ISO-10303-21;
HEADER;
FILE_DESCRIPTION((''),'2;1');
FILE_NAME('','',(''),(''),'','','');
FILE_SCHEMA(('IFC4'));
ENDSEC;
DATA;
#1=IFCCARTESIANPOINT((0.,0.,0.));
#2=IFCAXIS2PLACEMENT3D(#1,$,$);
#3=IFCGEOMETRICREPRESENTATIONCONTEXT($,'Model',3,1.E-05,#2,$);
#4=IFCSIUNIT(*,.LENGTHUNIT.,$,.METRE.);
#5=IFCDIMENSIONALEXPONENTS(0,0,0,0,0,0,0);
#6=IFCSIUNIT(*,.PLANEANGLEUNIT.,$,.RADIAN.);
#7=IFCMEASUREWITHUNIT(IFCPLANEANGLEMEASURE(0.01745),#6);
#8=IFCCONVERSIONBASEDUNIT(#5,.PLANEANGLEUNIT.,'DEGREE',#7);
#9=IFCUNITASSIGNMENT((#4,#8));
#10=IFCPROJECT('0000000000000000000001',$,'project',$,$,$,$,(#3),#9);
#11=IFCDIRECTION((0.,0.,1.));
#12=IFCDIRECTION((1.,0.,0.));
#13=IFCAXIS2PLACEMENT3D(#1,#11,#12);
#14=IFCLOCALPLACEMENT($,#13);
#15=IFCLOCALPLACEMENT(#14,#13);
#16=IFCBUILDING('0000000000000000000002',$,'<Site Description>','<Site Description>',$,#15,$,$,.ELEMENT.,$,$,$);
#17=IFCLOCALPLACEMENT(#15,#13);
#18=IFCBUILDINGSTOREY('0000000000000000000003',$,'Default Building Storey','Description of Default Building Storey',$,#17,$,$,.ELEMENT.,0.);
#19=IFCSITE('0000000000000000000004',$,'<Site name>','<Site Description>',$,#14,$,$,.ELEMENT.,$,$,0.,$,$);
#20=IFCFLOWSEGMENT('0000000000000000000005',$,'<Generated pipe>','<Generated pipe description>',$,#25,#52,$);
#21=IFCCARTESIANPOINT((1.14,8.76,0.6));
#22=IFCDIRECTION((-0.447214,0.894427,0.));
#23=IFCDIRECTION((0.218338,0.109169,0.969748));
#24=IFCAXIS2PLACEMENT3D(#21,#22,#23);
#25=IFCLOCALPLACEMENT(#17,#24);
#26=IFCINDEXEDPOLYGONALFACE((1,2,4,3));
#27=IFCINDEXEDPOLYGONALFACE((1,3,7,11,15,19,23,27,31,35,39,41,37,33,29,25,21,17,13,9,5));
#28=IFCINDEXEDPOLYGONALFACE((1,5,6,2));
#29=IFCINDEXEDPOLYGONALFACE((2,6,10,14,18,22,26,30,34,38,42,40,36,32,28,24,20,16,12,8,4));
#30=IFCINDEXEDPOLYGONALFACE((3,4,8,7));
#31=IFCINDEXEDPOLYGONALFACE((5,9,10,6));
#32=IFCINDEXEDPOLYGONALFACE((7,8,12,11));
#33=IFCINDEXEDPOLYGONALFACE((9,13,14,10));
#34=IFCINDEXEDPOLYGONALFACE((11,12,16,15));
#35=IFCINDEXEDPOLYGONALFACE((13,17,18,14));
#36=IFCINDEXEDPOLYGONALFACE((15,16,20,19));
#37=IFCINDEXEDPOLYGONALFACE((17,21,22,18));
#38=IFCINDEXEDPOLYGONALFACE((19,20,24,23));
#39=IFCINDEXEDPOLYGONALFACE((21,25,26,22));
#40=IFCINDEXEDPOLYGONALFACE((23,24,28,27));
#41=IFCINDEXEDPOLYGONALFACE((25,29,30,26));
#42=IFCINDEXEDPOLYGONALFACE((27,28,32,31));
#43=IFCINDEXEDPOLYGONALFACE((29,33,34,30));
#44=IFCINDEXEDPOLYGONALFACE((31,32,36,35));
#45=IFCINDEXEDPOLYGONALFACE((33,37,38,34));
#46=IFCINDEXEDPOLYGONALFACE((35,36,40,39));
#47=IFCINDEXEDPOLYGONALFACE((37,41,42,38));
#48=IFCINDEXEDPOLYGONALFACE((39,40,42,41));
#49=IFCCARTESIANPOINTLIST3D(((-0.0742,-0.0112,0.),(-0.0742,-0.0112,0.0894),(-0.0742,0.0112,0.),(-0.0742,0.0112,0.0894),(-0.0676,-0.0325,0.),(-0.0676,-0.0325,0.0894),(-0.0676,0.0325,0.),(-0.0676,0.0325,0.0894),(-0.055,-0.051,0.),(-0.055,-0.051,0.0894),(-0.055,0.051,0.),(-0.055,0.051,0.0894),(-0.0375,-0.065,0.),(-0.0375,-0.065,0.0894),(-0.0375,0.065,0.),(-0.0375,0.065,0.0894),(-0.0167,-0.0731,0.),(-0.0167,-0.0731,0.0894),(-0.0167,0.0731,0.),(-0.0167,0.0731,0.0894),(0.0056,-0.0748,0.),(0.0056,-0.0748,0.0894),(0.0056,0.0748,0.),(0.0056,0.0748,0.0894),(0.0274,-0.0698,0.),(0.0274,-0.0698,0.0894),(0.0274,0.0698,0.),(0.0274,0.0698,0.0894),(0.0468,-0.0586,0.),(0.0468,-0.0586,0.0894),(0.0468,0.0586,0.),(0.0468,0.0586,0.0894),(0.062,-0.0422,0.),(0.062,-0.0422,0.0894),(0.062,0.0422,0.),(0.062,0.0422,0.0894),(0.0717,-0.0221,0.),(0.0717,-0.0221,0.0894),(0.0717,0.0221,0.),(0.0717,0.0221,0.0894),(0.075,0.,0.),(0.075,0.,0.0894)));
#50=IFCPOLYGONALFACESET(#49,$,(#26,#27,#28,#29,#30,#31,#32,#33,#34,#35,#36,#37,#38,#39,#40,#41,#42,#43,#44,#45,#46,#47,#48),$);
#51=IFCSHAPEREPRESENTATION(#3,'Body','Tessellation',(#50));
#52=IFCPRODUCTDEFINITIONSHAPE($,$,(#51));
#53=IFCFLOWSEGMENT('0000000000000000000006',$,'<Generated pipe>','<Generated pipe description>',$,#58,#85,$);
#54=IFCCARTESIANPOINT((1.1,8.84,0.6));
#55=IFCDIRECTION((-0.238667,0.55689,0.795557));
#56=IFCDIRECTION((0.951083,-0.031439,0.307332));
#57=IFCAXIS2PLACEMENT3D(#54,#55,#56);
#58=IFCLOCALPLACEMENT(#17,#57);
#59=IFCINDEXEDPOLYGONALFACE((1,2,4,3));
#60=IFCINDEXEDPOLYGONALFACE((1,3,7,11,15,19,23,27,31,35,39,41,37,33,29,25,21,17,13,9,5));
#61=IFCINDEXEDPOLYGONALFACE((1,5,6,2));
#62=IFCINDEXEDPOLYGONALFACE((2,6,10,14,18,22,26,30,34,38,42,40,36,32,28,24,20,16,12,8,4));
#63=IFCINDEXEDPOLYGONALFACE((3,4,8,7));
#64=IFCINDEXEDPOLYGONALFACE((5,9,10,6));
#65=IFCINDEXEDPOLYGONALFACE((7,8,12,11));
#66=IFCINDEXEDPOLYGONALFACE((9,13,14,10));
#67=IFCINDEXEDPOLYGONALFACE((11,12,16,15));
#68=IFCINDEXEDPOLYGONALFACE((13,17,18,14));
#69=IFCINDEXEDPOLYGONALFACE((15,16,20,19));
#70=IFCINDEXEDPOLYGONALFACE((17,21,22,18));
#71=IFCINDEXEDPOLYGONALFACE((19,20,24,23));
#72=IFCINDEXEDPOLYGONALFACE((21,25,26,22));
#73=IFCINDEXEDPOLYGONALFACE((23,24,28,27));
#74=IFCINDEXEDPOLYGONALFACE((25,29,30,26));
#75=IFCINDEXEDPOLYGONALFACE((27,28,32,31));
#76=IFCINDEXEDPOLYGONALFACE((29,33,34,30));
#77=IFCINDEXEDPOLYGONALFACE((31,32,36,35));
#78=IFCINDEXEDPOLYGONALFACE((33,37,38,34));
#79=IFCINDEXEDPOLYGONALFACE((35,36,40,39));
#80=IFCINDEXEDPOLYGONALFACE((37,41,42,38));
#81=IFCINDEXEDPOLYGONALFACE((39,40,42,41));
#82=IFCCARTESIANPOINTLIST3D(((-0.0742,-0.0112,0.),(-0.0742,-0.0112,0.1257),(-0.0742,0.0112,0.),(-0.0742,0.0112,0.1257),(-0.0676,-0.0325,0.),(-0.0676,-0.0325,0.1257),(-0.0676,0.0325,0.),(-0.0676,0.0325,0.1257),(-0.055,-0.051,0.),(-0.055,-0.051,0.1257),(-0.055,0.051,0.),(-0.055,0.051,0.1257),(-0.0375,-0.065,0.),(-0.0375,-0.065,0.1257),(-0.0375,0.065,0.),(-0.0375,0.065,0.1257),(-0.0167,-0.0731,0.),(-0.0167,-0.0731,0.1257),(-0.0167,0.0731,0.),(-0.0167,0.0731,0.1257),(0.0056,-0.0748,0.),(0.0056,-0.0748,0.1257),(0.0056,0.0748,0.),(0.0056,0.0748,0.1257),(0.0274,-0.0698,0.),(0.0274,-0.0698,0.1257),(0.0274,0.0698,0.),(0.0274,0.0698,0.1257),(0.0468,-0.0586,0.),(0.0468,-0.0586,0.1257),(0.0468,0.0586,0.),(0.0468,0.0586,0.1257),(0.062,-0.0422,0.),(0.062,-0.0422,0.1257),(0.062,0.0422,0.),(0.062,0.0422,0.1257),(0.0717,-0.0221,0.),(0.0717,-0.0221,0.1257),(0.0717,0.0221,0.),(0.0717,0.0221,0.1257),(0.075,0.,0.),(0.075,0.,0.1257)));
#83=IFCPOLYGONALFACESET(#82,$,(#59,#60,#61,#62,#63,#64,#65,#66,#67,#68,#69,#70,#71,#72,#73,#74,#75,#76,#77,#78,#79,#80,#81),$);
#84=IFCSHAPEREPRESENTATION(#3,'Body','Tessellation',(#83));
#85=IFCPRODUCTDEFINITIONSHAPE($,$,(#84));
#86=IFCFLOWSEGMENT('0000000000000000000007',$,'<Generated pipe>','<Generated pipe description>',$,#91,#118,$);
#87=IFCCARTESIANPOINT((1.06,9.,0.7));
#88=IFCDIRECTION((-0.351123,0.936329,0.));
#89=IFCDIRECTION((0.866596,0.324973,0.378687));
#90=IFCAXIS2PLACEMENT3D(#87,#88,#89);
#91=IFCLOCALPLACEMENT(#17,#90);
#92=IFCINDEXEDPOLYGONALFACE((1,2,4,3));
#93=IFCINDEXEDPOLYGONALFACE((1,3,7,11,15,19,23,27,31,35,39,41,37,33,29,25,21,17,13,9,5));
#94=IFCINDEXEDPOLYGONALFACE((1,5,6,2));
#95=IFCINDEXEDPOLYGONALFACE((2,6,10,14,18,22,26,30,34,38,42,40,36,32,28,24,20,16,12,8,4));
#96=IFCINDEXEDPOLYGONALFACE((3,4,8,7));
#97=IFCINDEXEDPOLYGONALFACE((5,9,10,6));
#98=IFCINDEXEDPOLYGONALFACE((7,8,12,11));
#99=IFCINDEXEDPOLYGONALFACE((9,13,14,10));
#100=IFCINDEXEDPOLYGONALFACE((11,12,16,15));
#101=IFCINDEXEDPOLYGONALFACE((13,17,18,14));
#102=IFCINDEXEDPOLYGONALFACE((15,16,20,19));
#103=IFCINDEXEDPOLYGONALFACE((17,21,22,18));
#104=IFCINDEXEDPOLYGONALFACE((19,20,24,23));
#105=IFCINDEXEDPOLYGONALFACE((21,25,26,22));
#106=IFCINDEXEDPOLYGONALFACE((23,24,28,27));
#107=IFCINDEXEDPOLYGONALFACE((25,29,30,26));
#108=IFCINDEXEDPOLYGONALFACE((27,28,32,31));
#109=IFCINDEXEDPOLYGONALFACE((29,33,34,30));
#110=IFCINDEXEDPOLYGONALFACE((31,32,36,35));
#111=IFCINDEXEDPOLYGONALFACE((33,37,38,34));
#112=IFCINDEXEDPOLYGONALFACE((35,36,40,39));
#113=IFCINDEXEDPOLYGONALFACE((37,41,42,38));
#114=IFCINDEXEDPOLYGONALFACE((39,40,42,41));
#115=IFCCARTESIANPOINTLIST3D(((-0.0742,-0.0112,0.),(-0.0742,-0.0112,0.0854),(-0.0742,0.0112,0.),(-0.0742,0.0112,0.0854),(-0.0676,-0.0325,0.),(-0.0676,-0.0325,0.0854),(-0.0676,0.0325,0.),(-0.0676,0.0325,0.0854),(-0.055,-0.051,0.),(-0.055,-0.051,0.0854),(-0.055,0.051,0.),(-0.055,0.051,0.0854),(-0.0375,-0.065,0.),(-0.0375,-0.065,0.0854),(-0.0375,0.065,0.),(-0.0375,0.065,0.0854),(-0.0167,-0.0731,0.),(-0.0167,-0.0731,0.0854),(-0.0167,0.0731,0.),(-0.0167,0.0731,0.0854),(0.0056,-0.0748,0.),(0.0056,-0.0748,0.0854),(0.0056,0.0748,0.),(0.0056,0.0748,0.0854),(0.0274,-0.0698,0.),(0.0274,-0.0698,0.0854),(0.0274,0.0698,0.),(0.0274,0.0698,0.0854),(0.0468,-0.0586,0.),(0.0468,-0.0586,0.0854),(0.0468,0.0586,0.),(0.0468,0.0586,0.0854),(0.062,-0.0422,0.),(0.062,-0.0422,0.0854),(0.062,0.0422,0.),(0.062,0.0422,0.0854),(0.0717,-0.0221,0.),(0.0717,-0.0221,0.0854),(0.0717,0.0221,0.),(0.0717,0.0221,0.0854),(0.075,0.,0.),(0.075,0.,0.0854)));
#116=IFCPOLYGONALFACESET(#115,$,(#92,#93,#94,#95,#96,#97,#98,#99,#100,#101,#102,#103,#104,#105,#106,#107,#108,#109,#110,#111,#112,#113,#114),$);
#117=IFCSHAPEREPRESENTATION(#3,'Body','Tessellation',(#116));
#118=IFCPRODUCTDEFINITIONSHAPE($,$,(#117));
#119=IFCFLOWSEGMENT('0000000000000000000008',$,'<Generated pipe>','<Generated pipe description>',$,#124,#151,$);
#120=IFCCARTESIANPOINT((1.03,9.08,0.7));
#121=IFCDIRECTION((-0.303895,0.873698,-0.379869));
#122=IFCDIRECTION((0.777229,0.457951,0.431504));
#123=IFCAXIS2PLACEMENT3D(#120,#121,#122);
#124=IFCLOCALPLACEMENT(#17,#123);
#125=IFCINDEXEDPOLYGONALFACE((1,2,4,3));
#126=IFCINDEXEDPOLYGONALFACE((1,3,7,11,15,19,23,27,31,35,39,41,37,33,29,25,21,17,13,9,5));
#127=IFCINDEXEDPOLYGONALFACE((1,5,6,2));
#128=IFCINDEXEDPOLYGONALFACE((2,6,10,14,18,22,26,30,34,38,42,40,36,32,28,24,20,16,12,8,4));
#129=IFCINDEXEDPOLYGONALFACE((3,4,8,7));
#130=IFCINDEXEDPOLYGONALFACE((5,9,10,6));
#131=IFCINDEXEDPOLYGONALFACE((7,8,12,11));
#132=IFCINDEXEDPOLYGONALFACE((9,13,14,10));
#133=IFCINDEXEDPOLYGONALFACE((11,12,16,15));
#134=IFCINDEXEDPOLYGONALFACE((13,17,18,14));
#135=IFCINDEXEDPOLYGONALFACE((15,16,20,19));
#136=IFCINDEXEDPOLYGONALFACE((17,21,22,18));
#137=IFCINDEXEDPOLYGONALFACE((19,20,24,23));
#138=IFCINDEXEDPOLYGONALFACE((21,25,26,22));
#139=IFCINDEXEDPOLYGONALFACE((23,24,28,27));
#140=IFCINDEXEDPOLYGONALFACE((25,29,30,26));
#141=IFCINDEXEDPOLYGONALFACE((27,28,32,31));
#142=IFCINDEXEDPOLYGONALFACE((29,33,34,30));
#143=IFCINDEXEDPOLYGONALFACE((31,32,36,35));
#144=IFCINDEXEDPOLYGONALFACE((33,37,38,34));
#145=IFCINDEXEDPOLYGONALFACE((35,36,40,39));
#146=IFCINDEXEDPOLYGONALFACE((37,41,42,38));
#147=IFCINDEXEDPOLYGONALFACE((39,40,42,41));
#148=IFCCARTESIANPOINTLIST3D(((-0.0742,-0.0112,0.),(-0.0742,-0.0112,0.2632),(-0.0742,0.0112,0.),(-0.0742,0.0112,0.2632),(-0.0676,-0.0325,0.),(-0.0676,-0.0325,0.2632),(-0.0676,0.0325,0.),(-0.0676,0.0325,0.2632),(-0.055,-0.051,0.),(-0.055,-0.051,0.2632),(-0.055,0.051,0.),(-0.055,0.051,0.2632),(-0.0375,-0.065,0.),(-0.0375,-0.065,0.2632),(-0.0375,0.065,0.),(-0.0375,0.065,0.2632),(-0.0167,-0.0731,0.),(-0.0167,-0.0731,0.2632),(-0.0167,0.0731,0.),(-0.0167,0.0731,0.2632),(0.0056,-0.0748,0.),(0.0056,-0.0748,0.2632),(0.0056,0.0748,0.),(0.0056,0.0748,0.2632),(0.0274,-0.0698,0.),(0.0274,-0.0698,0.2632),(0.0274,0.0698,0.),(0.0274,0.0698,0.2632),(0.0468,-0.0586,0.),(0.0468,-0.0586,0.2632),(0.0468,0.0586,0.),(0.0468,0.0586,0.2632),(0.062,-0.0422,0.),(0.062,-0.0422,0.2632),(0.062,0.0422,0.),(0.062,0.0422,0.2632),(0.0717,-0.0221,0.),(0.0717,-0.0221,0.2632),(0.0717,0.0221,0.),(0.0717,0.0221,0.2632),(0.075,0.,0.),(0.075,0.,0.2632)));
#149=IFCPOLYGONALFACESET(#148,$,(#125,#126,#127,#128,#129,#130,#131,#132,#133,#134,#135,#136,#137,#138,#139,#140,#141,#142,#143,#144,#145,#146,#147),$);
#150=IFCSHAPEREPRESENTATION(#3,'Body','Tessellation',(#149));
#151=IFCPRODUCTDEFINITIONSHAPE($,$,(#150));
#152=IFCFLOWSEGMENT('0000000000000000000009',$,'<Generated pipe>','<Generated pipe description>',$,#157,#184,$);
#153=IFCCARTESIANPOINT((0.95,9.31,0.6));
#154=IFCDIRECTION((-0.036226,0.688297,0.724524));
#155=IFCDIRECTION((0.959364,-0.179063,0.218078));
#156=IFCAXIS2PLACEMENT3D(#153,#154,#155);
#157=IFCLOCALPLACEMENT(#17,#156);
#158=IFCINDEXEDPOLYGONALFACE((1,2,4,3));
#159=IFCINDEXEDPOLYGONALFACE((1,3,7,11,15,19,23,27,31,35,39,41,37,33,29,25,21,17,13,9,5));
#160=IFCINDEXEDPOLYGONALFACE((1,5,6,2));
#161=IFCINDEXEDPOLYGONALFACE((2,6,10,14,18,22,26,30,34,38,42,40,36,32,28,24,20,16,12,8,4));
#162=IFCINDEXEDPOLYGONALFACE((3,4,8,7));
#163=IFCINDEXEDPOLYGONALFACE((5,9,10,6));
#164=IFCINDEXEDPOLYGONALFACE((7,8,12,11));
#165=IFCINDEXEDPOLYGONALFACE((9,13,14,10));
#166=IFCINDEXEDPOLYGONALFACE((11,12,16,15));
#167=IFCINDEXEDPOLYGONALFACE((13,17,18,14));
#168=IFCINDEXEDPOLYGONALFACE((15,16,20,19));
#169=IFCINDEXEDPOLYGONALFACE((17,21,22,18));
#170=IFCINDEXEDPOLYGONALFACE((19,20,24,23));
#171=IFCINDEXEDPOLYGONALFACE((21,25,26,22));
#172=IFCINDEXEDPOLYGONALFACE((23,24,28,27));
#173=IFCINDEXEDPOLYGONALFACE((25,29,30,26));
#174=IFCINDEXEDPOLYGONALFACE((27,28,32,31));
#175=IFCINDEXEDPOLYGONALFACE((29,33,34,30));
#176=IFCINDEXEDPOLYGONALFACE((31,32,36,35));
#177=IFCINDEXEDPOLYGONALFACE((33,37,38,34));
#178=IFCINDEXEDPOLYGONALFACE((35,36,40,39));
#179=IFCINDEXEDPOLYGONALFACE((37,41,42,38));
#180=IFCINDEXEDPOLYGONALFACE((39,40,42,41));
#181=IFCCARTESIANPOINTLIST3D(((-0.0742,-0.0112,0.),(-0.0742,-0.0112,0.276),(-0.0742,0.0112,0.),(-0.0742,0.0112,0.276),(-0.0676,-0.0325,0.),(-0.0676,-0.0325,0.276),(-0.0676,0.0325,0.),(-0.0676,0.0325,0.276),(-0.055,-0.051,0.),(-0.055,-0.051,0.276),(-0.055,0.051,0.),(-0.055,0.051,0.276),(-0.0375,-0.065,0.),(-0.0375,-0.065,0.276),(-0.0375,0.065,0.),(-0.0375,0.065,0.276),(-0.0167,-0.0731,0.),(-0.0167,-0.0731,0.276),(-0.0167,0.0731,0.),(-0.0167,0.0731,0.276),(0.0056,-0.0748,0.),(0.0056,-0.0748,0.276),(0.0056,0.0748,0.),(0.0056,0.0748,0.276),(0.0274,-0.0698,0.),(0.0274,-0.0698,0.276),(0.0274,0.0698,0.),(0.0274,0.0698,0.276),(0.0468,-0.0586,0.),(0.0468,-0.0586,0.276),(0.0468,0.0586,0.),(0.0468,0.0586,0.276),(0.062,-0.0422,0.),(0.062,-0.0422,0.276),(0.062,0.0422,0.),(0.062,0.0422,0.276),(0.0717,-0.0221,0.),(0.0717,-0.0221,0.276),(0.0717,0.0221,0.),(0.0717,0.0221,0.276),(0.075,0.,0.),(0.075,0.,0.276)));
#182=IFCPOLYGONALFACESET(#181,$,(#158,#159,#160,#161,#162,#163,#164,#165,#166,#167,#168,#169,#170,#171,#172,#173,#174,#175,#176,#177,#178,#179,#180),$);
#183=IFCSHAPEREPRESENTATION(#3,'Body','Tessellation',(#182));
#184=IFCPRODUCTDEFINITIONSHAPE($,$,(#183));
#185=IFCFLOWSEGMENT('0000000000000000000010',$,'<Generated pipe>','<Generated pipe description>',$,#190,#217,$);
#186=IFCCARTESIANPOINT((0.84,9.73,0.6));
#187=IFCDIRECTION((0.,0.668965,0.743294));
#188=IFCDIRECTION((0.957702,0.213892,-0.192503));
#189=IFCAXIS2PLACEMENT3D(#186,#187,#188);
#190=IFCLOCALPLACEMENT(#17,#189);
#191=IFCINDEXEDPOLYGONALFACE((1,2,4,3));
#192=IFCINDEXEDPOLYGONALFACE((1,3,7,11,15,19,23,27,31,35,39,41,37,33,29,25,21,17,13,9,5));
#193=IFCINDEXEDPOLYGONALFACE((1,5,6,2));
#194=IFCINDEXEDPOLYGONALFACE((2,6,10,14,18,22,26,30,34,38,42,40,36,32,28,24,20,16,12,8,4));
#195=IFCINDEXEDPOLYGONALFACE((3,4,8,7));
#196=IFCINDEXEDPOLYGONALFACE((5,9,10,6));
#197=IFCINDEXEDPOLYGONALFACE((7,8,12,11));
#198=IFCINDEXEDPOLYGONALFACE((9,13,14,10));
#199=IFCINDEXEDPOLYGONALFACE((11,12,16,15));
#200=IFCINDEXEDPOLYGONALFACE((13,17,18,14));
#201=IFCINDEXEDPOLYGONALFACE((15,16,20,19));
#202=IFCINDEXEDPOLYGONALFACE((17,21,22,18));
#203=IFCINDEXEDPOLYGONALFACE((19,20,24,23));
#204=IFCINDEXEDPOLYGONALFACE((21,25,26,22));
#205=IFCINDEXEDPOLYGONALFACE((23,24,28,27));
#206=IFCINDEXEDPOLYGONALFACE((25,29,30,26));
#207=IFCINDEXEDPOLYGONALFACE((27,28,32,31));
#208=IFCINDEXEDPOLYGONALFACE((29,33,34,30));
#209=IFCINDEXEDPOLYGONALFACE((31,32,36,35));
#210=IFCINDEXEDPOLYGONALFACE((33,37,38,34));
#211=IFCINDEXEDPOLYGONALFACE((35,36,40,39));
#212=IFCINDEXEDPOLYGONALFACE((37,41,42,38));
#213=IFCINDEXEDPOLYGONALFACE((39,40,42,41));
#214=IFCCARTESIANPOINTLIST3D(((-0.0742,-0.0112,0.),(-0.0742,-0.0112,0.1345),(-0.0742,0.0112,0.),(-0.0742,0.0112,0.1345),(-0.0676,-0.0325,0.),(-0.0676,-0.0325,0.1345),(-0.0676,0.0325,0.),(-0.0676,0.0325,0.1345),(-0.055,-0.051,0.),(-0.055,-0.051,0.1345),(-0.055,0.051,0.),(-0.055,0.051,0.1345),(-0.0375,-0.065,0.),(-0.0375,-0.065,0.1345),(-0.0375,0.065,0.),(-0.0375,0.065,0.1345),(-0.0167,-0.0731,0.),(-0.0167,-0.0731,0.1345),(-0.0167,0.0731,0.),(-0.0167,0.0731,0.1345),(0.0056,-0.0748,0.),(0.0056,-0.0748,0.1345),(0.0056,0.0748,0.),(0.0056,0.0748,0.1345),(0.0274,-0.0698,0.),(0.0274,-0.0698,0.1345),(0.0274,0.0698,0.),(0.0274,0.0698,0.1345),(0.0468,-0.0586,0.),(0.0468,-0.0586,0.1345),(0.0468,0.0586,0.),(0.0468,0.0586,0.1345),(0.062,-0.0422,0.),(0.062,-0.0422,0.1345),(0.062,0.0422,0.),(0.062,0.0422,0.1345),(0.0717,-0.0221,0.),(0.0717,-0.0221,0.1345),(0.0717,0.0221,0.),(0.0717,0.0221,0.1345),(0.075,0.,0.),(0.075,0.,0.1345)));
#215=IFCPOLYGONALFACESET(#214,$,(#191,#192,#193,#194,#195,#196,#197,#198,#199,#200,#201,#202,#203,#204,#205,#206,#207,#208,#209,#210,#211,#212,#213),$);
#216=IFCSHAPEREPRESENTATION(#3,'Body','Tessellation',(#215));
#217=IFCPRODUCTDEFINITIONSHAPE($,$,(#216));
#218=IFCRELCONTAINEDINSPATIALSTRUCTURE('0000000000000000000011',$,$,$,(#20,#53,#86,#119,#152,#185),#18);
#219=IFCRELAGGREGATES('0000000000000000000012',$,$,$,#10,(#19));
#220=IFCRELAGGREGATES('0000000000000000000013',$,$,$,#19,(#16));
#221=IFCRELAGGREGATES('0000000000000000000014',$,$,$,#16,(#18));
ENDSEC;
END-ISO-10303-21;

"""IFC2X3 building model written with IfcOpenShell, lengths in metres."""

from ifc_helpers import new_model, entity, si_unit, converted_unit, frame, origin, origin_with_axes, origin_2d_with_axis, place, context, project, spatial, circle, extrude, element, save


model = new_model("IFC2X3")

# Units and contexts
model_context = context("Model", 3, precision=1e-05, world=origin())
ifc_project = project(units=[si_unit("LENGTHUNIT", "METRE"), converted_unit("PLANEANGLEUNIT", "DEGREE", entity("IfcPlaneAngleMeasure", 0.01745), si_unit("PLANEANGLEUNIT", "RADIAN"), dimensions=[0, 0, 0, 0, 0, 0, 0])], contexts=[model_context])

# Site, building, storey
site_placement = place(None, origin_with_axes())
site = spatial("IfcSite", under=ifc_project, at=site_placement, Name="<Site name>", Description="<Site Description>", CompositionType="ELEMENT", RefElevation=0.0)
building_placement = place(site_placement, origin_with_axes())
building = spatial("IfcBuilding", under=site, at=building_placement, Name="<Site Description>", Description="<Site Description>", CompositionType="ELEMENT")
storey_placement = place(building_placement, origin_with_axes())
storey = spatial("IfcBuildingStorey", under=building, at=storey_placement, Name="Default Building Storey", Description="Description of Default Building Storey", CompositionType="ELEMENT", Elevation=0.0)

# Flow segments
flow_segment_1_placement = place(storey_placement, frame((1.14, 8.76, 0.6), z_axis=(-0.447214, 0.894427, 0.0), x_axis=(0.218338, 0.109169, 0.969748)))
element("IfcFlowSegment", 1, at=flow_segment_1_placement, inside=storey, Name="<Generated pipe>", Description="<Generated pipe description>", context=model_context, shape_type="SweptSolid", body=[
    extrude(circle(Radius=0.075, at=origin_2d_with_axis()), origin_with_axes(), (0.0, 0.0, 1.0), 0.0894),
])
flow_segment_2_placement = place(storey_placement, frame((1.1, 8.84, 0.6), z_axis=(-0.238667, 0.55689, 0.795557), x_axis=(0.951083, -0.031439, 0.307332)))
element("IfcFlowSegment", 2, at=flow_segment_2_placement, inside=storey, Name="<Generated pipe>", Description="<Generated pipe description>", context=model_context, shape_type="SweptSolid", body=[
    extrude(circle(Radius=0.075, at=origin_2d_with_axis()), origin_with_axes(), (0.0, 0.0, 1.0), 0.1257),
])
flow_segment_3_placement = place(storey_placement, frame((1.06, 9.0, 0.7), z_axis=(-0.351123, 0.936329, 0.0), x_axis=(0.866596, 0.324973, 0.378687)))
element("IfcFlowSegment", 3, at=flow_segment_3_placement, inside=storey, Name="<Generated pipe>", Description="<Generated pipe description>", context=model_context, shape_type="SweptSolid", body=[
    extrude(circle(Radius=0.075, at=origin_2d_with_axis()), origin_with_axes(), (0.0, 0.0, 1.0), 0.0854),
])
flow_segment_4_placement = place(storey_placement, frame((1.03, 9.08, 0.7), z_axis=(-0.303895, 0.873698, -0.379869), x_axis=(0.777229, 0.457951, 0.431504)))
element("IfcFlowSegment", 4, at=flow_segment_4_placement, inside=storey, Name="<Generated pipe>", Description="<Generated pipe description>", context=model_context, shape_type="SweptSolid", body=[
    extrude(circle(Radius=0.075, at=origin_2d_with_axis()), origin_with_axes(), (0.0, 0.0, 1.0), 0.2632),
])
flow_segment_5_placement = place(storey_placement, frame((0.95, 9.31, 0.6), z_axis=(-0.036226, 0.688297, 0.724524), x_axis=(0.959364, -0.179063, 0.218078)))
element("IfcFlowSegment", 5, at=flow_segment_5_placement, inside=storey, Name="<Generated pipe>", Description="<Generated pipe description>", context=model_context, shape_type="SweptSolid", body=[
    extrude(circle(Radius=0.075, at=origin_2d_with_axis()), origin_with_axes(), (0.0, 0.0, 1.0), 0.276),
])
flow_segment_6_placement = place(storey_placement, frame((0.84, 9.73, 0.6), z_axis=(0.0, 0.668965, 0.743294), x_axis=(0.957702, 0.213892, -0.192503)))
element("IfcFlowSegment", 6, at=flow_segment_6_placement, inside=storey, Name="<Generated pipe>", Description="<Generated pipe description>", context=model_context, shape_type="SweptSolid", body=[
    extrude(circle(Radius=0.075, at=origin_2d_with_axis()), origin_with_axes(), (0.0, 0.0, 1.0), 0.1345),
])

save(model, "model.ifc")
